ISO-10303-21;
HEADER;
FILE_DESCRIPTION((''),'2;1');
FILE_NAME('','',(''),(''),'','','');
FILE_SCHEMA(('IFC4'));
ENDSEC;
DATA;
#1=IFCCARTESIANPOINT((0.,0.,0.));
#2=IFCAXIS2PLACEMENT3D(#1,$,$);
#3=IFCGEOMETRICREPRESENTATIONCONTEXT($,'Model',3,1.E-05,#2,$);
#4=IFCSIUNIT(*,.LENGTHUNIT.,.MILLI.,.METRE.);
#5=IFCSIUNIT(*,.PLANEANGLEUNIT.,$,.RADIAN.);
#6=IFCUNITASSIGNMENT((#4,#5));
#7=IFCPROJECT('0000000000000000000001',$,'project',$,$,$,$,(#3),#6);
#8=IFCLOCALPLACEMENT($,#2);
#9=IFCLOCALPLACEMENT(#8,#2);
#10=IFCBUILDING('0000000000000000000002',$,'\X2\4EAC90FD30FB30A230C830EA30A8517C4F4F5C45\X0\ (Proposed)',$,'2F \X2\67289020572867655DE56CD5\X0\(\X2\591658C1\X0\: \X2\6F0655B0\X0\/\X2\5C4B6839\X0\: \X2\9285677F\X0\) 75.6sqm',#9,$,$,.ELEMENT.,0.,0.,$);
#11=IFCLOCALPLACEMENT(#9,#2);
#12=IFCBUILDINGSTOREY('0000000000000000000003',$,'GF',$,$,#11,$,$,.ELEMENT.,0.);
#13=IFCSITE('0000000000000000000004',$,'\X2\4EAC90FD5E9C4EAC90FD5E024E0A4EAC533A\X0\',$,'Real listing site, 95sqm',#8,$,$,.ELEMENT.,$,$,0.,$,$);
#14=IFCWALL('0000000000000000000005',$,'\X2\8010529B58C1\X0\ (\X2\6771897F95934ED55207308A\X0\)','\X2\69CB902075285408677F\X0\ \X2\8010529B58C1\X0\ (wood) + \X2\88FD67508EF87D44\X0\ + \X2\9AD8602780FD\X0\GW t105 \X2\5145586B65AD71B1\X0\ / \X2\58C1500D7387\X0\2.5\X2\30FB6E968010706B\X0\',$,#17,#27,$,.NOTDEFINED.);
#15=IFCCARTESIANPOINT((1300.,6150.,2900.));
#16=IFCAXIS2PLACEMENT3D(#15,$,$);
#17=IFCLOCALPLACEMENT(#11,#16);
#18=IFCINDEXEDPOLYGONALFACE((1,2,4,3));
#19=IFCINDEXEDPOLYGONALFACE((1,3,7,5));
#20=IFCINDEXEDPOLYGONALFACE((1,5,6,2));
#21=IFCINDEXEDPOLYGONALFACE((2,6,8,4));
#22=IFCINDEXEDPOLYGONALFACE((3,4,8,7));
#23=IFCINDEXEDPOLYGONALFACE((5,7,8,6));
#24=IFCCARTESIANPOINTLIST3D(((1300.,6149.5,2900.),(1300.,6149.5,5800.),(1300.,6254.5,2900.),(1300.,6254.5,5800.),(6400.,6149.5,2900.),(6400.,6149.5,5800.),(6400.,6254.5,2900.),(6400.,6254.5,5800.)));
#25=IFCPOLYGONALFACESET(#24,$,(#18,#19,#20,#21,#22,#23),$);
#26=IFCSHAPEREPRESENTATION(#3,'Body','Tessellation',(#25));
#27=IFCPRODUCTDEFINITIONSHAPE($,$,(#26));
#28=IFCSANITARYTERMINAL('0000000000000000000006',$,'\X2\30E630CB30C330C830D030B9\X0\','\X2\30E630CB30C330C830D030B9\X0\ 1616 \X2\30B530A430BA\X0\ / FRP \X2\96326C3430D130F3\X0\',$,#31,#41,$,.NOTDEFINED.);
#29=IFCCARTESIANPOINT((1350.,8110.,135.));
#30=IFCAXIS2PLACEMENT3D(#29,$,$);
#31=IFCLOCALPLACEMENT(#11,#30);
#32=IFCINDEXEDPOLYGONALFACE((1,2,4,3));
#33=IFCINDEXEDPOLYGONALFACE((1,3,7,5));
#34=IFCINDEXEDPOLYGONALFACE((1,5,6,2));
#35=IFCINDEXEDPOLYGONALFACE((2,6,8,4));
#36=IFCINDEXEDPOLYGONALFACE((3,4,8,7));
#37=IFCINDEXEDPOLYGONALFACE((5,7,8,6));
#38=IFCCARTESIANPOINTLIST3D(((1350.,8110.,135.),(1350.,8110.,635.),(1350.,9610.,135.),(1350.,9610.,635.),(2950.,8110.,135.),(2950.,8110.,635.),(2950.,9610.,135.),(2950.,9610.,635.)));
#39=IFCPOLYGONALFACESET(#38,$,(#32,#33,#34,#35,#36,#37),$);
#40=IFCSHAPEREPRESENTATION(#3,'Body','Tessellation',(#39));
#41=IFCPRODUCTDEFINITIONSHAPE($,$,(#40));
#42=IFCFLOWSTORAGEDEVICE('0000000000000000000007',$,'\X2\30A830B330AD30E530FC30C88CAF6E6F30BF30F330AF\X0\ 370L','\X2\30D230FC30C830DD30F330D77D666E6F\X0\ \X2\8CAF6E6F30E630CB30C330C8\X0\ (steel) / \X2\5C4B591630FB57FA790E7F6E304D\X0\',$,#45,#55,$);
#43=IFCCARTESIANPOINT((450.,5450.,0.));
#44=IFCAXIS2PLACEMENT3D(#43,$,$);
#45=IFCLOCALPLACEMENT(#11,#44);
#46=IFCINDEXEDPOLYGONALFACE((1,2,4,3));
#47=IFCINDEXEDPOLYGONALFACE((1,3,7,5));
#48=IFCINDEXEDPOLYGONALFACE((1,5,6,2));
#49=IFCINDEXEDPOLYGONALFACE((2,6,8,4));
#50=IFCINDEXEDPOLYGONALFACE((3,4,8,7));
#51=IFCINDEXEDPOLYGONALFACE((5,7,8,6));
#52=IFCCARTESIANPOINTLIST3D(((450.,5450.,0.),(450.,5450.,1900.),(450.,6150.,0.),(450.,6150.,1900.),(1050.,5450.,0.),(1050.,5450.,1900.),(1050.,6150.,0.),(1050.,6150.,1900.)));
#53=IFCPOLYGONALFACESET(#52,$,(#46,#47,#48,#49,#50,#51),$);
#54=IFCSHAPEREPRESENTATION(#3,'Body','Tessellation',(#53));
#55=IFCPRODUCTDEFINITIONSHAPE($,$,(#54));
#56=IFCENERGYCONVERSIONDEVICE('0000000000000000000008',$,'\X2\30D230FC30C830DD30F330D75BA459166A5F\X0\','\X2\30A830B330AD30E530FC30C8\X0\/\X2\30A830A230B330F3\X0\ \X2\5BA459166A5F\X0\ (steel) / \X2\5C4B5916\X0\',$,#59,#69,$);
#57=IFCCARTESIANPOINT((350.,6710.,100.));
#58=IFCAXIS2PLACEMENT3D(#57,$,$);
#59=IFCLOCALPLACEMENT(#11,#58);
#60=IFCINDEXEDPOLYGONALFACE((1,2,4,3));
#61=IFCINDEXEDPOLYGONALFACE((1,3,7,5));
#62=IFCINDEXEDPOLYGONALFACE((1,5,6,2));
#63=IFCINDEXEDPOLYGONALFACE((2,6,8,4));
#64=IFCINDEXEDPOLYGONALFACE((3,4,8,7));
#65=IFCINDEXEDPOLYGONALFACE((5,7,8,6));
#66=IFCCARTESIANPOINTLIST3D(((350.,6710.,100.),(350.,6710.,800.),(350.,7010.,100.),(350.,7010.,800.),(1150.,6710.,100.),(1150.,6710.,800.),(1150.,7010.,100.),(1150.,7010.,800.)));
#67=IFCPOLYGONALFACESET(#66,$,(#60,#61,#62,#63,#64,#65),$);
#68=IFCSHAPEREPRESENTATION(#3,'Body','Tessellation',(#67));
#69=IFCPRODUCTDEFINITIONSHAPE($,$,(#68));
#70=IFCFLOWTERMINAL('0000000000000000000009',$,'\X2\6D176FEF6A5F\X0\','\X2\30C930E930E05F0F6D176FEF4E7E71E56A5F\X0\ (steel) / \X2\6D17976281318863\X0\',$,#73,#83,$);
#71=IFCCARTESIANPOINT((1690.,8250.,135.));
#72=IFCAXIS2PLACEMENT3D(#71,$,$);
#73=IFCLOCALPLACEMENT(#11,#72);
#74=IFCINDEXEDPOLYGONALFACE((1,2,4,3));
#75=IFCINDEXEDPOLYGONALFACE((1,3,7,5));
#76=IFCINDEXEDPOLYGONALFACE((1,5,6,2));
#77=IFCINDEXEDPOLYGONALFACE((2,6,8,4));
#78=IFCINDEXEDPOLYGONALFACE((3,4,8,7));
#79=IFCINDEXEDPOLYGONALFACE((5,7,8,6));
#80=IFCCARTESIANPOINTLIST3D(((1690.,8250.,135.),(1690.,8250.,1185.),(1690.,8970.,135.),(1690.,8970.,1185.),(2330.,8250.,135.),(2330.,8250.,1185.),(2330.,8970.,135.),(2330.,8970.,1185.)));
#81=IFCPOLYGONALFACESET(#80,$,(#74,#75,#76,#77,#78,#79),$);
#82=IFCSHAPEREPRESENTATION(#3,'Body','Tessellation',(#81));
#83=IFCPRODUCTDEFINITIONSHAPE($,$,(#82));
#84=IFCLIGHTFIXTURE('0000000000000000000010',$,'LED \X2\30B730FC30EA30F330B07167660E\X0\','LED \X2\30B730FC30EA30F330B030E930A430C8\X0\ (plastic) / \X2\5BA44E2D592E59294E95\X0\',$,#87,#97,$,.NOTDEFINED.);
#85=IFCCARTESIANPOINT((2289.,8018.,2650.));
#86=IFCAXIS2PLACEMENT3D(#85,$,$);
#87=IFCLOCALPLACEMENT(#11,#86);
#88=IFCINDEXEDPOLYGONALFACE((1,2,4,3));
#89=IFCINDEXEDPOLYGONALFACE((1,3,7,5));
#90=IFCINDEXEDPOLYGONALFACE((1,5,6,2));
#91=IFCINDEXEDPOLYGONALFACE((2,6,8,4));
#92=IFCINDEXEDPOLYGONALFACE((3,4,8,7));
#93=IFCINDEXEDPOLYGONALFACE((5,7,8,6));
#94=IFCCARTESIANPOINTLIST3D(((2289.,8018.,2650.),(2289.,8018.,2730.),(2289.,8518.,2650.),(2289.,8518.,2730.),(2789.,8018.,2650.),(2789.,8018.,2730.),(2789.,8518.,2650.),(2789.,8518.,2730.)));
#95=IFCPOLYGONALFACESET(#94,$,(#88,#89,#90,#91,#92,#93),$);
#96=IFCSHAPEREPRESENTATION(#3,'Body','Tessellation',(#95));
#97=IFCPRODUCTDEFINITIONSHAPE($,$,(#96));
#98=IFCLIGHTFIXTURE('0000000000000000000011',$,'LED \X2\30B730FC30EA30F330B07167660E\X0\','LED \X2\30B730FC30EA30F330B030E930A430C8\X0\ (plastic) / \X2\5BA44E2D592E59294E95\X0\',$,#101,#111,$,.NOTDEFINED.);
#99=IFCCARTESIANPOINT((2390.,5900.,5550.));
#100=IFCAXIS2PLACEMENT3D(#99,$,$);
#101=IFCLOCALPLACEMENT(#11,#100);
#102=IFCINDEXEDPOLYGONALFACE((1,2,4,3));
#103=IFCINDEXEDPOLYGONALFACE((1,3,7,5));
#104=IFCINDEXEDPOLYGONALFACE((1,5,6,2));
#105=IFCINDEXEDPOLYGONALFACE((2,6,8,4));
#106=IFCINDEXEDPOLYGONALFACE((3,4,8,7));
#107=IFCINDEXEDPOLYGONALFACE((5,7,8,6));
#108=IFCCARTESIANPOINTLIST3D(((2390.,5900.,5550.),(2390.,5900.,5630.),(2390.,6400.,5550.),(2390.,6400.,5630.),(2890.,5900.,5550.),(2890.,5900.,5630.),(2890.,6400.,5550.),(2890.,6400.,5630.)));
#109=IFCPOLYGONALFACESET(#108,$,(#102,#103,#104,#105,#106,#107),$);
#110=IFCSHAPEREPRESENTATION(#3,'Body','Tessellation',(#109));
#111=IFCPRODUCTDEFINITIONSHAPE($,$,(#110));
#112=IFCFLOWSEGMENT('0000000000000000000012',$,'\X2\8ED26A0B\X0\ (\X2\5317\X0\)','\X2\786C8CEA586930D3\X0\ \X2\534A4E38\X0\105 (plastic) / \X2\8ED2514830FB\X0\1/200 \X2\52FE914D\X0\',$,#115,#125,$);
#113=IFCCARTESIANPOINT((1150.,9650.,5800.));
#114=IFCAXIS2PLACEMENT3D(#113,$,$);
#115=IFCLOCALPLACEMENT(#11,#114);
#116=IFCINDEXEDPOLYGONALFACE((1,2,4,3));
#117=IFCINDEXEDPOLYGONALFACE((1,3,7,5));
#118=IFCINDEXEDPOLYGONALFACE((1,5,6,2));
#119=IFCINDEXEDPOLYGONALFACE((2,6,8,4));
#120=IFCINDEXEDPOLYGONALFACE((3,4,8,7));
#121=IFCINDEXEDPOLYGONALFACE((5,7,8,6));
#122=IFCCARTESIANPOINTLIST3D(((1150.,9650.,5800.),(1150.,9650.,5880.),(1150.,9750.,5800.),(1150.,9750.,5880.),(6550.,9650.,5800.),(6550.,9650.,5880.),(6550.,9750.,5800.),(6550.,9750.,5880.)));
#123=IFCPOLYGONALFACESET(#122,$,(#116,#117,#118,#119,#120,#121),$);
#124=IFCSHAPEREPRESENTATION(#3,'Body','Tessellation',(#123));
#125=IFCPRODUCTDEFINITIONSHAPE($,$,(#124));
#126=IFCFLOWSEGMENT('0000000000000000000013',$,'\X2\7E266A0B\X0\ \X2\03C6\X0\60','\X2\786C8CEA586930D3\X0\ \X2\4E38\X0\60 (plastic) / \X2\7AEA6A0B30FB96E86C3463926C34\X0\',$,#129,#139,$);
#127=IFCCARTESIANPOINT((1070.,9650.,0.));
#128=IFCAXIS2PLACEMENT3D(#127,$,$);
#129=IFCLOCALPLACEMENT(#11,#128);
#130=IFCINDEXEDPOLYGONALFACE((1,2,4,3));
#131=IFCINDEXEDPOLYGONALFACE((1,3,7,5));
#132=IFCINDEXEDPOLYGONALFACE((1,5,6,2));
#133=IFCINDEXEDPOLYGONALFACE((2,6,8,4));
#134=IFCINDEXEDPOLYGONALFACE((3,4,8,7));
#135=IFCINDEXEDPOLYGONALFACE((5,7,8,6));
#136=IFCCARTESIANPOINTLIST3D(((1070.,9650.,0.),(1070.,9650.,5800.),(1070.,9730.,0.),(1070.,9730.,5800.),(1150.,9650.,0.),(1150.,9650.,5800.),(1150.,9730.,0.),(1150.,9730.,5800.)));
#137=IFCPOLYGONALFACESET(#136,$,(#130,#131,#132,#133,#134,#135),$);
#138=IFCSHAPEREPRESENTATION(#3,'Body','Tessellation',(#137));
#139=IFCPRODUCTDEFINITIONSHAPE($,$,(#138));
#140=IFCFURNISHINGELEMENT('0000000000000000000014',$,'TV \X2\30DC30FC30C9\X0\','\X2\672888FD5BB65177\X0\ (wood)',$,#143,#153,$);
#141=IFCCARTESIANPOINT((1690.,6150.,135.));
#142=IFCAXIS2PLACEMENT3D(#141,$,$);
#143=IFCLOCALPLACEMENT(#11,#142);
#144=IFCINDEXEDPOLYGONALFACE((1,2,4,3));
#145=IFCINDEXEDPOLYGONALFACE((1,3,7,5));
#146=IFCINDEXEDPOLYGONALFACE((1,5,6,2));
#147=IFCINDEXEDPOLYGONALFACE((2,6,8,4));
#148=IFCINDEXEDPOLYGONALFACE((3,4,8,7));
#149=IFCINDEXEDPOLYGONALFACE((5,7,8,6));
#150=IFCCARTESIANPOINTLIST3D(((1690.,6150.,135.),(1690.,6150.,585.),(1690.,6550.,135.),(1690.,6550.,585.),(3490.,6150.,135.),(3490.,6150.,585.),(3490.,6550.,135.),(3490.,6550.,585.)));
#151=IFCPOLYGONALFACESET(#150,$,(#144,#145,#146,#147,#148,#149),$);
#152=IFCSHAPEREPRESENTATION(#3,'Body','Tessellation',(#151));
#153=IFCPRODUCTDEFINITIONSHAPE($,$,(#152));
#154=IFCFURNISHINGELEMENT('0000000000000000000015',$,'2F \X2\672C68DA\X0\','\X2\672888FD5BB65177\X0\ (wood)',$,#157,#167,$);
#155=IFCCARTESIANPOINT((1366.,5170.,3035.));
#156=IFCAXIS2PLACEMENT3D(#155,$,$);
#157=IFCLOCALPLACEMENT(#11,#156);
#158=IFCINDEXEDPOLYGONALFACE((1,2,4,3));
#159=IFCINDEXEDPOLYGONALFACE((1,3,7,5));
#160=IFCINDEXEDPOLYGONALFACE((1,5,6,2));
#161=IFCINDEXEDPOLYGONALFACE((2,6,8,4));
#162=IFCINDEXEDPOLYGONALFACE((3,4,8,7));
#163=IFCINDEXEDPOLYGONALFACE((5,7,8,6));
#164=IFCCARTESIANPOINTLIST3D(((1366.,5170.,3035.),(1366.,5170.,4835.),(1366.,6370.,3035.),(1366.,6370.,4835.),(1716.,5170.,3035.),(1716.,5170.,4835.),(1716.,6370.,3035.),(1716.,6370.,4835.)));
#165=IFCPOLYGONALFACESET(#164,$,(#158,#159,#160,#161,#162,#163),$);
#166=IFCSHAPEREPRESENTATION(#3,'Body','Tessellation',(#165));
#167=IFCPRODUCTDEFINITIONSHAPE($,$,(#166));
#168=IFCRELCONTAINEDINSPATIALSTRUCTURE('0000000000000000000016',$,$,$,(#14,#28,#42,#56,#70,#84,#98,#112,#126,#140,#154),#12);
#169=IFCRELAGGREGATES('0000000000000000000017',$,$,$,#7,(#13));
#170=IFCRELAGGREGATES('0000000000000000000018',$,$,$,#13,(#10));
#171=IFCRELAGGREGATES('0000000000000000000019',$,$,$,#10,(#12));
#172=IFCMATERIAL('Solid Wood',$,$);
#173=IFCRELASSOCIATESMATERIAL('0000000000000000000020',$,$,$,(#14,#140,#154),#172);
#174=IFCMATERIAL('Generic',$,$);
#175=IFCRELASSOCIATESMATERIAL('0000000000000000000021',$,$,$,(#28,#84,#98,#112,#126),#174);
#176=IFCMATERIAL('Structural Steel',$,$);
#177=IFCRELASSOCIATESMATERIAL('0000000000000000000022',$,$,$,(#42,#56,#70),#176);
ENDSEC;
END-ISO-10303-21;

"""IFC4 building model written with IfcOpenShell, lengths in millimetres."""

from ifc_helpers import new_model, si_unit, frame, frame_2d, origin, place, context, project, spatial, rectangle, extrude, material, element, save


model = new_model("IFC4")

# Units and contexts
model_context = context("Model", 3, precision=1e-05, world=origin())
ifc_project = project(units=[si_unit("LENGTHUNIT", "METRE", prefix="MILLI"), si_unit("PLANEANGLEUNIT", "RADIAN")], contexts=[model_context])

# Site, building, storey
site_placement = place(None, origin())
site = spatial("IfcSite", under=ifc_project, at=site_placement, Name="京都府京都市上京区", ObjectType="Real listing site, 95sqm", CompositionType="ELEMENT", RefElevation=0.0)
building_placement = place(site_placement, origin())
building = spatial("IfcBuilding", under=site, at=building_placement, Name="京都・アトリエ兼住居 (Proposed)", ObjectType="2F 木造在来工法(外壁: 漆喰/屋根: 銅板) 75.6sqm", CompositionType="ELEMENT", ElevationOfRefHeight=0.0, ElevationOfTerrain=0.0)
storey_placement = place(building_placement, origin())
storey = spatial("IfcBuildingStorey", under=building, at=storey_placement, Name="GF", CompositionType="ELEMENT", Elevation=0.0)

# Shared definitions
ifc_material_1 = material(Name="Solid Wood")

# Wall
wall_1_placement = place(storey_placement, frame((1300.0, 6150.0, 2900.0)))
element("IfcWall", 1, at=wall_1_placement, inside=storey, material=ifc_material_1, Name="耐力壁 (東西間仕切り)", Description="構造用合板 耐力壁 (wood) + 製材軸組 + 高性能GW t105 充填断熱 / 壁倍率2.5・準耐火", PredefinedType="NOTDEFINED", context=model_context, shape_type="SweptSolid", body=[
    extrude(rectangle(XDim=5100.0, YDim=105.0, at=frame_2d((2550.0, 52.0))), frame((1300.0, 6150.0, 2900.0)), (0.0, 0.0, 1.0), 2900.0),
])

# Sanitary terminal
ifc_material_2 = material(Name="Generic")
sanitary_terminal_placement = place(storey_placement, frame((1350.0, 8110.0, 135.0)))
element("IfcSanitaryTerminal", 2, at=sanitary_terminal_placement, inside=storey, material=ifc_material_2, Name="ユニットバス", Description="ユニットバス 1616 サイズ / FRP 防水パン", PredefinedType="NOTDEFINED", context=model_context, shape_type="SweptSolid", body=[
    extrude(rectangle(XDim=1600.0, YDim=1500.0, at=frame_2d((800.0, 750.0))), frame((1350.0, 8110.0, 135.0)), (0.0, 0.0, 1.0), 500.0),
])

# Flow storage device
ifc_material_3 = material(Name="Structural Steel")
flow_storage_device_placement = place(storey_placement, frame((450.0, 5450.0, 0.0)))
element("IfcFlowStorageDevice", 3, at=flow_storage_device_placement, inside=storey, material=ifc_material_3, Name="エコキュート貯湯タンク 370L", Description="ヒートポンプ給湯 貯湯ユニット (steel) / 屋外・基礎置き", context=model_context, shape_type="SweptSolid", body=[
    extrude(rectangle(XDim=600.0, YDim=700.0, at=frame_2d((300.0, 350.0))), frame((450.0, 5450.0, 0.0)), (0.0, 0.0, 1.0), 1900.0),
])

# Energy conversion device
energy_conversion_device_placement = place(storey_placement, frame((350.0, 6710.0, 100.0)))
element("IfcEnergyConversionDevice", 4, at=energy_conversion_device_placement, inside=storey, material=ifc_material_3, Name="ヒートポンプ室外機", Description="エコキュート/エアコン 室外機 (steel) / 屋外", context=model_context, shape_type="SweptSolid", body=[
    extrude(rectangle(XDim=800.0, YDim=300.0, at=frame_2d((400.0, 150.0))), frame((350.0, 6710.0, 100.0)), (0.0, 0.0, 1.0), 700.0),
])

# Flow terminal
flow_terminal_placement = place(storey_placement, frame((1690.0, 8250.0, 135.0)))
element("IfcFlowTerminal", 5, at=flow_terminal_placement, inside=storey, material=ifc_material_3, Name="洗濯機", Description="ドラム式洗濯乾燥機 (steel) / 洗面脱衣", context=model_context, shape_type="SweptSolid", body=[
    extrude(rectangle(XDim=640.0, YDim=720.0, at=frame_2d((320.0, 360.0))), frame((1690.0, 8250.0, 135.0)), (0.0, 0.0, 1.0), 1050.0),
])

# Light fixtures
light_fixture_1_placement = place(storey_placement, frame((2289.0, 8018.0, 2650.0)))
element("IfcLightFixture", 6, at=light_fixture_1_placement, inside=storey, material=ifc_material_2, Name="LED シーリング照明", Description="LED シーリングライト (plastic) / 室中央天井", PredefinedType="NOTDEFINED", context=model_context, shape_type="SweptSolid", body=[
    extrude(rectangle(XDim=500.0, YDim=500.0, at=frame_2d((250.0, 250.0))), frame((2289.0, 8018.0, 2650.0)), (0.0, 0.0, 1.0), 80.0),
])
light_fixture_2_placement = place(storey_placement, frame((2390.0, 5900.0, 5550.0)))
element("IfcLightFixture", 7, at=light_fixture_2_placement, inside=storey, material=ifc_material_2, Name="LED シーリング照明", Description="LED シーリングライト (plastic) / 室中央天井", PredefinedType="NOTDEFINED", context=model_context, shape_type="SweptSolid", body=[
    extrude(rectangle(XDim=500.0, YDim=500.0, at=frame_2d((250.0, 250.0))), frame((2390.0, 5900.0, 5550.0)), (0.0, 0.0, 1.0), 80.0),
])

# Flow segments
flow_segment_1_placement = place(storey_placement, frame((1150.0, 9650.0, 5800.0)))
element("IfcFlowSegment", 8, at=flow_segment_1_placement, inside=storey, material=ifc_material_2, Name="軒樋 (北)", Description="硬質塩ビ 半丸105 (plastic) / 軒先・1/200 勾配", context=model_context, shape_type="SweptSolid", body=[
    extrude(rectangle(XDim=5400.0, YDim=100.0, at=frame_2d((2700.0, 50.0))), frame((1150.0, 9650.0, 5800.0)), (0.0, 0.0, 1.0), 80.0),
])
flow_segment_2_placement = place(storey_placement, frame((1070.0, 9650.0, 0.0)))
element("IfcFlowSegment", 9, at=flow_segment_2_placement, inside=storey, material=ifc_material_2, Name="縦樋 φ60", Description="硬質塩ビ 丸60 (plastic) / 竪樋・雨水排水", context=model_context, shape_type="SweptSolid", body=[
    extrude(rectangle(XDim=80.0, YDim=80.0, at=frame_2d((40.0, 40.0))), frame((1070.0, 9650.0, 0.0)), (0.0, 0.0, 1.0), 5800.0),
])

# Furnishing elements
furnishing_1_placement = place(storey_placement, frame((1690.0, 6150.0, 135.0)))
element("IfcFurnishingElement", 10, at=furnishing_1_placement, inside=storey, material=ifc_material_1, Name="TV ボード", Description="木製家具 (wood)", context=model_context, shape_type="SweptSolid", body=[
    extrude(rectangle(XDim=1800.0, YDim=400.0, at=frame_2d((900.0, 200.0))), frame((1690.0, 6150.0, 135.0)), (0.0, 0.0, 1.0), 450.0),
])
furnishing_2_placement = place(storey_placement, frame((1366.0, 5170.0, 3035.0)))
element("IfcFurnishingElement", 11, at=furnishing_2_placement, inside=storey, material=ifc_material_1, Name="2F 本棚", Description="木製家具 (wood)", context=model_context, shape_type="SweptSolid", body=[
    extrude(rectangle(XDim=350.0, YDim=1200.0, at=frame_2d((175.0, 600.0))), frame((1366.0, 5170.0, 3035.0)), (0.0, 0.0, 1.0), 1800.0),
])

save(model, "model.ifc")
